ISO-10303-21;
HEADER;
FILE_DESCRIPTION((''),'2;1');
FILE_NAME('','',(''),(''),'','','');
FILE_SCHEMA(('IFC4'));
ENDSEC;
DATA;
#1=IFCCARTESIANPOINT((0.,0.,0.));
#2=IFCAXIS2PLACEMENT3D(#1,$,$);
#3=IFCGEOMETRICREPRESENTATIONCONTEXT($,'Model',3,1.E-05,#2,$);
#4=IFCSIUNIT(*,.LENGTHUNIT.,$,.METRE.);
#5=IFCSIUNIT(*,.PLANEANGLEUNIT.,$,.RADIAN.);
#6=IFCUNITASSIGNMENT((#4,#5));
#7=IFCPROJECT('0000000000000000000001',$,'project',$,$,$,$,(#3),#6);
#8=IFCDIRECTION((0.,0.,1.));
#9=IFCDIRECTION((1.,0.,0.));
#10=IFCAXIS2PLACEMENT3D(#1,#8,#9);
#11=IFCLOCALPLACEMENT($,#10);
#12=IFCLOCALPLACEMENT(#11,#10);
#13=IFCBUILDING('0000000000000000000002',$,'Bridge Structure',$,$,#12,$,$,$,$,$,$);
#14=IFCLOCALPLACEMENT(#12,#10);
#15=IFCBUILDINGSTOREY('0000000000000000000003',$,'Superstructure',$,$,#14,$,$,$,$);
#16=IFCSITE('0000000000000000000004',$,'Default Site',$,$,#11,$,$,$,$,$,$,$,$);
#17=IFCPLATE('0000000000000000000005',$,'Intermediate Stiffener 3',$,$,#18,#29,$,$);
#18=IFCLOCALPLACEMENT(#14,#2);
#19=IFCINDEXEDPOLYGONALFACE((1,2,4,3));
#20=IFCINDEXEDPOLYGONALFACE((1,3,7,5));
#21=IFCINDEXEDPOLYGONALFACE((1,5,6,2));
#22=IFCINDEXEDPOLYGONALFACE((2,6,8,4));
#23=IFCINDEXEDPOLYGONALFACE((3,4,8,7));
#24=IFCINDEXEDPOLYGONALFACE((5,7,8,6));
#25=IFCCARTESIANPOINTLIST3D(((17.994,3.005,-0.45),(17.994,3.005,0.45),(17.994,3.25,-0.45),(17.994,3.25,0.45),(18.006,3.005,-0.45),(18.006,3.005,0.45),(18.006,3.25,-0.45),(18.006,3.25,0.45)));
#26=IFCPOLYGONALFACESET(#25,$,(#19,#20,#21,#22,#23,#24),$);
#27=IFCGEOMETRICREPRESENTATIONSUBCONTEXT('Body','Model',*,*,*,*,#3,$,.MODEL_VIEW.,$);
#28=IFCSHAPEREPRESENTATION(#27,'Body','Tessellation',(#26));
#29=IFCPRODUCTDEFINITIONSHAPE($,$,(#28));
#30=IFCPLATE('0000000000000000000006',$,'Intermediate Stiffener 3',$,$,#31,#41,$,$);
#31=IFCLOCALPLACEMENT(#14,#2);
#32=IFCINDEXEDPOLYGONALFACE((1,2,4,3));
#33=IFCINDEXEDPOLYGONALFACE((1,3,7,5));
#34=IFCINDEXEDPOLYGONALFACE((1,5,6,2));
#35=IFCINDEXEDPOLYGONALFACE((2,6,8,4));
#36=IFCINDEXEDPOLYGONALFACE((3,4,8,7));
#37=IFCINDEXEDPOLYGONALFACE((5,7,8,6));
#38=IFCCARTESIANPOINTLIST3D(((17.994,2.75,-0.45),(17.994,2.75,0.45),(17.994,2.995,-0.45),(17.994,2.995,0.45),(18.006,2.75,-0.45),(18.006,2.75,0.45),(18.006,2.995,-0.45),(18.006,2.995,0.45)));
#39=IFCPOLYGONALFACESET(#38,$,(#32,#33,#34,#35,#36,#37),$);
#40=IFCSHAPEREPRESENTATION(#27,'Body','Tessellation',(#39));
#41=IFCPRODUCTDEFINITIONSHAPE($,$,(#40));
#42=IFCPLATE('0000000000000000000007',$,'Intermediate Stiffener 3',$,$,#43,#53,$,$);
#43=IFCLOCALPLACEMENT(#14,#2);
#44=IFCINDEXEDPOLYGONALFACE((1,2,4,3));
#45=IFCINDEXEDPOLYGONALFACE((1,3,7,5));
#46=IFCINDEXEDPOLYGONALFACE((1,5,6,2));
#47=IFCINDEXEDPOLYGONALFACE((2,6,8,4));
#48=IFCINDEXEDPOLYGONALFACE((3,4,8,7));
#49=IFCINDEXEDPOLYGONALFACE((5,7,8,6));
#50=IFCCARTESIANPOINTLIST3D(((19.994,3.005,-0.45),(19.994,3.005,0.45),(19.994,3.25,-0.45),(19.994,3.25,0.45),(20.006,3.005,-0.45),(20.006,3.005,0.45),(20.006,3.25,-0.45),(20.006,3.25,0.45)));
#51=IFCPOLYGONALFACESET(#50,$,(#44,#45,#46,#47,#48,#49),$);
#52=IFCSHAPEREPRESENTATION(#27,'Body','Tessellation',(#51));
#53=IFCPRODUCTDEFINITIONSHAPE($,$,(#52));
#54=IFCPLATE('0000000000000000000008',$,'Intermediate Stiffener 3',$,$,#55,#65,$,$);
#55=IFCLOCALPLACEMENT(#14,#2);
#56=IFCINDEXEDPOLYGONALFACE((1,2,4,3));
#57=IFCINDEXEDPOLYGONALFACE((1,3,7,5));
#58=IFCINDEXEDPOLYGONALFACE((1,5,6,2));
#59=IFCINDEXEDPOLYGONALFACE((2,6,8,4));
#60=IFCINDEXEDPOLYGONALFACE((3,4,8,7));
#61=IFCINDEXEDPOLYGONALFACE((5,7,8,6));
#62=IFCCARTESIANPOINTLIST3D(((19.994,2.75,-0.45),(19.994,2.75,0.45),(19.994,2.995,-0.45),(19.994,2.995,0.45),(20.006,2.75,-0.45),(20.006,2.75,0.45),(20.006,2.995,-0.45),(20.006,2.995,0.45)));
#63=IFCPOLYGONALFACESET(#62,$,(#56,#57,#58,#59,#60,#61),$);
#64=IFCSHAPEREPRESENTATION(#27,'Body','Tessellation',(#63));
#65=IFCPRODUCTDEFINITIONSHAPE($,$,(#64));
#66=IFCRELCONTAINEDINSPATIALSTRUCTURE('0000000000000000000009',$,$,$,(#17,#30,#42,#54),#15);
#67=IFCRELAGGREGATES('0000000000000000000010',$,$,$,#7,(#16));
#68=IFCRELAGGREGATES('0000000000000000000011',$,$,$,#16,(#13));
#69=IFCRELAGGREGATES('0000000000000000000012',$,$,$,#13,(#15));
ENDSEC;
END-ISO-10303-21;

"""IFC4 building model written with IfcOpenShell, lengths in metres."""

from ifc_helpers import new_model, si_unit, frame, origin, origin_with_axes, origin_2d_with_axis, place, context, subcontext, project, spatial, rectangle, extrude, element, save


model = new_model("IFC4")

# Units and contexts
model_context = context("Model", 3, precision=1e-05, world=origin())
body_context = subcontext(model_context, "Body", "Model", "MODEL_VIEW")
ifc_project = project(units=[si_unit("LENGTHUNIT", "METRE"), si_unit("PLANEANGLEUNIT", "RADIAN")], contexts=[model_context])

# Site, building, storey
site_placement = place(None, origin_with_axes())
site = spatial("IfcSite", under=ifc_project, at=site_placement, Name="Default Site")
building_placement = place(site_placement, origin_with_axes())
building = spatial("IfcBuilding", under=site, at=building_placement, Name="Bridge Structure")
storey_placement = place(building_placement, origin_with_axes())
storey = spatial("IfcBuildingStorey", under=building, at=storey_placement, Name="Superstructure")

# Plates
for number, where, z_axis, x_axis, name in (
    (1, (18.0, 3.1275, -0.45), (0.0, 0.0, 1.0), (1.0, 0.0, 0.0), "Intermediate Stiffener 3"),
    (2, (18.0, 2.8725, -0.45), (0.0, 0.0, 1.0), (1.0, 0.0, 0.0), "Intermediate Stiffener 3"),
    (3, (20.0, 3.1275, -0.45), (0.0, 0.0, 1.0), (1.0, 0.0, 0.0), "Intermediate Stiffener 3"),
    (4, (20.0, 2.8725, -0.45), (0.0, 0.0, 1.0), (1.0, 0.0, 0.0), "Intermediate Stiffener 3"),
):
    element("IfcPlate", number, at=place(storey_placement, frame(where, z_axis=z_axis, x_axis=x_axis)), inside=storey, Name=name, context=body_context, shape_type="SweptSolid", body=[
        extrude(rectangle(XDim=0.012, YDim=0.245, at=origin_2d_with_axis()), origin_with_axes(), (0.0, 0.0, 1.0), 0.9),
    ])

save(model, "model.ifc")
